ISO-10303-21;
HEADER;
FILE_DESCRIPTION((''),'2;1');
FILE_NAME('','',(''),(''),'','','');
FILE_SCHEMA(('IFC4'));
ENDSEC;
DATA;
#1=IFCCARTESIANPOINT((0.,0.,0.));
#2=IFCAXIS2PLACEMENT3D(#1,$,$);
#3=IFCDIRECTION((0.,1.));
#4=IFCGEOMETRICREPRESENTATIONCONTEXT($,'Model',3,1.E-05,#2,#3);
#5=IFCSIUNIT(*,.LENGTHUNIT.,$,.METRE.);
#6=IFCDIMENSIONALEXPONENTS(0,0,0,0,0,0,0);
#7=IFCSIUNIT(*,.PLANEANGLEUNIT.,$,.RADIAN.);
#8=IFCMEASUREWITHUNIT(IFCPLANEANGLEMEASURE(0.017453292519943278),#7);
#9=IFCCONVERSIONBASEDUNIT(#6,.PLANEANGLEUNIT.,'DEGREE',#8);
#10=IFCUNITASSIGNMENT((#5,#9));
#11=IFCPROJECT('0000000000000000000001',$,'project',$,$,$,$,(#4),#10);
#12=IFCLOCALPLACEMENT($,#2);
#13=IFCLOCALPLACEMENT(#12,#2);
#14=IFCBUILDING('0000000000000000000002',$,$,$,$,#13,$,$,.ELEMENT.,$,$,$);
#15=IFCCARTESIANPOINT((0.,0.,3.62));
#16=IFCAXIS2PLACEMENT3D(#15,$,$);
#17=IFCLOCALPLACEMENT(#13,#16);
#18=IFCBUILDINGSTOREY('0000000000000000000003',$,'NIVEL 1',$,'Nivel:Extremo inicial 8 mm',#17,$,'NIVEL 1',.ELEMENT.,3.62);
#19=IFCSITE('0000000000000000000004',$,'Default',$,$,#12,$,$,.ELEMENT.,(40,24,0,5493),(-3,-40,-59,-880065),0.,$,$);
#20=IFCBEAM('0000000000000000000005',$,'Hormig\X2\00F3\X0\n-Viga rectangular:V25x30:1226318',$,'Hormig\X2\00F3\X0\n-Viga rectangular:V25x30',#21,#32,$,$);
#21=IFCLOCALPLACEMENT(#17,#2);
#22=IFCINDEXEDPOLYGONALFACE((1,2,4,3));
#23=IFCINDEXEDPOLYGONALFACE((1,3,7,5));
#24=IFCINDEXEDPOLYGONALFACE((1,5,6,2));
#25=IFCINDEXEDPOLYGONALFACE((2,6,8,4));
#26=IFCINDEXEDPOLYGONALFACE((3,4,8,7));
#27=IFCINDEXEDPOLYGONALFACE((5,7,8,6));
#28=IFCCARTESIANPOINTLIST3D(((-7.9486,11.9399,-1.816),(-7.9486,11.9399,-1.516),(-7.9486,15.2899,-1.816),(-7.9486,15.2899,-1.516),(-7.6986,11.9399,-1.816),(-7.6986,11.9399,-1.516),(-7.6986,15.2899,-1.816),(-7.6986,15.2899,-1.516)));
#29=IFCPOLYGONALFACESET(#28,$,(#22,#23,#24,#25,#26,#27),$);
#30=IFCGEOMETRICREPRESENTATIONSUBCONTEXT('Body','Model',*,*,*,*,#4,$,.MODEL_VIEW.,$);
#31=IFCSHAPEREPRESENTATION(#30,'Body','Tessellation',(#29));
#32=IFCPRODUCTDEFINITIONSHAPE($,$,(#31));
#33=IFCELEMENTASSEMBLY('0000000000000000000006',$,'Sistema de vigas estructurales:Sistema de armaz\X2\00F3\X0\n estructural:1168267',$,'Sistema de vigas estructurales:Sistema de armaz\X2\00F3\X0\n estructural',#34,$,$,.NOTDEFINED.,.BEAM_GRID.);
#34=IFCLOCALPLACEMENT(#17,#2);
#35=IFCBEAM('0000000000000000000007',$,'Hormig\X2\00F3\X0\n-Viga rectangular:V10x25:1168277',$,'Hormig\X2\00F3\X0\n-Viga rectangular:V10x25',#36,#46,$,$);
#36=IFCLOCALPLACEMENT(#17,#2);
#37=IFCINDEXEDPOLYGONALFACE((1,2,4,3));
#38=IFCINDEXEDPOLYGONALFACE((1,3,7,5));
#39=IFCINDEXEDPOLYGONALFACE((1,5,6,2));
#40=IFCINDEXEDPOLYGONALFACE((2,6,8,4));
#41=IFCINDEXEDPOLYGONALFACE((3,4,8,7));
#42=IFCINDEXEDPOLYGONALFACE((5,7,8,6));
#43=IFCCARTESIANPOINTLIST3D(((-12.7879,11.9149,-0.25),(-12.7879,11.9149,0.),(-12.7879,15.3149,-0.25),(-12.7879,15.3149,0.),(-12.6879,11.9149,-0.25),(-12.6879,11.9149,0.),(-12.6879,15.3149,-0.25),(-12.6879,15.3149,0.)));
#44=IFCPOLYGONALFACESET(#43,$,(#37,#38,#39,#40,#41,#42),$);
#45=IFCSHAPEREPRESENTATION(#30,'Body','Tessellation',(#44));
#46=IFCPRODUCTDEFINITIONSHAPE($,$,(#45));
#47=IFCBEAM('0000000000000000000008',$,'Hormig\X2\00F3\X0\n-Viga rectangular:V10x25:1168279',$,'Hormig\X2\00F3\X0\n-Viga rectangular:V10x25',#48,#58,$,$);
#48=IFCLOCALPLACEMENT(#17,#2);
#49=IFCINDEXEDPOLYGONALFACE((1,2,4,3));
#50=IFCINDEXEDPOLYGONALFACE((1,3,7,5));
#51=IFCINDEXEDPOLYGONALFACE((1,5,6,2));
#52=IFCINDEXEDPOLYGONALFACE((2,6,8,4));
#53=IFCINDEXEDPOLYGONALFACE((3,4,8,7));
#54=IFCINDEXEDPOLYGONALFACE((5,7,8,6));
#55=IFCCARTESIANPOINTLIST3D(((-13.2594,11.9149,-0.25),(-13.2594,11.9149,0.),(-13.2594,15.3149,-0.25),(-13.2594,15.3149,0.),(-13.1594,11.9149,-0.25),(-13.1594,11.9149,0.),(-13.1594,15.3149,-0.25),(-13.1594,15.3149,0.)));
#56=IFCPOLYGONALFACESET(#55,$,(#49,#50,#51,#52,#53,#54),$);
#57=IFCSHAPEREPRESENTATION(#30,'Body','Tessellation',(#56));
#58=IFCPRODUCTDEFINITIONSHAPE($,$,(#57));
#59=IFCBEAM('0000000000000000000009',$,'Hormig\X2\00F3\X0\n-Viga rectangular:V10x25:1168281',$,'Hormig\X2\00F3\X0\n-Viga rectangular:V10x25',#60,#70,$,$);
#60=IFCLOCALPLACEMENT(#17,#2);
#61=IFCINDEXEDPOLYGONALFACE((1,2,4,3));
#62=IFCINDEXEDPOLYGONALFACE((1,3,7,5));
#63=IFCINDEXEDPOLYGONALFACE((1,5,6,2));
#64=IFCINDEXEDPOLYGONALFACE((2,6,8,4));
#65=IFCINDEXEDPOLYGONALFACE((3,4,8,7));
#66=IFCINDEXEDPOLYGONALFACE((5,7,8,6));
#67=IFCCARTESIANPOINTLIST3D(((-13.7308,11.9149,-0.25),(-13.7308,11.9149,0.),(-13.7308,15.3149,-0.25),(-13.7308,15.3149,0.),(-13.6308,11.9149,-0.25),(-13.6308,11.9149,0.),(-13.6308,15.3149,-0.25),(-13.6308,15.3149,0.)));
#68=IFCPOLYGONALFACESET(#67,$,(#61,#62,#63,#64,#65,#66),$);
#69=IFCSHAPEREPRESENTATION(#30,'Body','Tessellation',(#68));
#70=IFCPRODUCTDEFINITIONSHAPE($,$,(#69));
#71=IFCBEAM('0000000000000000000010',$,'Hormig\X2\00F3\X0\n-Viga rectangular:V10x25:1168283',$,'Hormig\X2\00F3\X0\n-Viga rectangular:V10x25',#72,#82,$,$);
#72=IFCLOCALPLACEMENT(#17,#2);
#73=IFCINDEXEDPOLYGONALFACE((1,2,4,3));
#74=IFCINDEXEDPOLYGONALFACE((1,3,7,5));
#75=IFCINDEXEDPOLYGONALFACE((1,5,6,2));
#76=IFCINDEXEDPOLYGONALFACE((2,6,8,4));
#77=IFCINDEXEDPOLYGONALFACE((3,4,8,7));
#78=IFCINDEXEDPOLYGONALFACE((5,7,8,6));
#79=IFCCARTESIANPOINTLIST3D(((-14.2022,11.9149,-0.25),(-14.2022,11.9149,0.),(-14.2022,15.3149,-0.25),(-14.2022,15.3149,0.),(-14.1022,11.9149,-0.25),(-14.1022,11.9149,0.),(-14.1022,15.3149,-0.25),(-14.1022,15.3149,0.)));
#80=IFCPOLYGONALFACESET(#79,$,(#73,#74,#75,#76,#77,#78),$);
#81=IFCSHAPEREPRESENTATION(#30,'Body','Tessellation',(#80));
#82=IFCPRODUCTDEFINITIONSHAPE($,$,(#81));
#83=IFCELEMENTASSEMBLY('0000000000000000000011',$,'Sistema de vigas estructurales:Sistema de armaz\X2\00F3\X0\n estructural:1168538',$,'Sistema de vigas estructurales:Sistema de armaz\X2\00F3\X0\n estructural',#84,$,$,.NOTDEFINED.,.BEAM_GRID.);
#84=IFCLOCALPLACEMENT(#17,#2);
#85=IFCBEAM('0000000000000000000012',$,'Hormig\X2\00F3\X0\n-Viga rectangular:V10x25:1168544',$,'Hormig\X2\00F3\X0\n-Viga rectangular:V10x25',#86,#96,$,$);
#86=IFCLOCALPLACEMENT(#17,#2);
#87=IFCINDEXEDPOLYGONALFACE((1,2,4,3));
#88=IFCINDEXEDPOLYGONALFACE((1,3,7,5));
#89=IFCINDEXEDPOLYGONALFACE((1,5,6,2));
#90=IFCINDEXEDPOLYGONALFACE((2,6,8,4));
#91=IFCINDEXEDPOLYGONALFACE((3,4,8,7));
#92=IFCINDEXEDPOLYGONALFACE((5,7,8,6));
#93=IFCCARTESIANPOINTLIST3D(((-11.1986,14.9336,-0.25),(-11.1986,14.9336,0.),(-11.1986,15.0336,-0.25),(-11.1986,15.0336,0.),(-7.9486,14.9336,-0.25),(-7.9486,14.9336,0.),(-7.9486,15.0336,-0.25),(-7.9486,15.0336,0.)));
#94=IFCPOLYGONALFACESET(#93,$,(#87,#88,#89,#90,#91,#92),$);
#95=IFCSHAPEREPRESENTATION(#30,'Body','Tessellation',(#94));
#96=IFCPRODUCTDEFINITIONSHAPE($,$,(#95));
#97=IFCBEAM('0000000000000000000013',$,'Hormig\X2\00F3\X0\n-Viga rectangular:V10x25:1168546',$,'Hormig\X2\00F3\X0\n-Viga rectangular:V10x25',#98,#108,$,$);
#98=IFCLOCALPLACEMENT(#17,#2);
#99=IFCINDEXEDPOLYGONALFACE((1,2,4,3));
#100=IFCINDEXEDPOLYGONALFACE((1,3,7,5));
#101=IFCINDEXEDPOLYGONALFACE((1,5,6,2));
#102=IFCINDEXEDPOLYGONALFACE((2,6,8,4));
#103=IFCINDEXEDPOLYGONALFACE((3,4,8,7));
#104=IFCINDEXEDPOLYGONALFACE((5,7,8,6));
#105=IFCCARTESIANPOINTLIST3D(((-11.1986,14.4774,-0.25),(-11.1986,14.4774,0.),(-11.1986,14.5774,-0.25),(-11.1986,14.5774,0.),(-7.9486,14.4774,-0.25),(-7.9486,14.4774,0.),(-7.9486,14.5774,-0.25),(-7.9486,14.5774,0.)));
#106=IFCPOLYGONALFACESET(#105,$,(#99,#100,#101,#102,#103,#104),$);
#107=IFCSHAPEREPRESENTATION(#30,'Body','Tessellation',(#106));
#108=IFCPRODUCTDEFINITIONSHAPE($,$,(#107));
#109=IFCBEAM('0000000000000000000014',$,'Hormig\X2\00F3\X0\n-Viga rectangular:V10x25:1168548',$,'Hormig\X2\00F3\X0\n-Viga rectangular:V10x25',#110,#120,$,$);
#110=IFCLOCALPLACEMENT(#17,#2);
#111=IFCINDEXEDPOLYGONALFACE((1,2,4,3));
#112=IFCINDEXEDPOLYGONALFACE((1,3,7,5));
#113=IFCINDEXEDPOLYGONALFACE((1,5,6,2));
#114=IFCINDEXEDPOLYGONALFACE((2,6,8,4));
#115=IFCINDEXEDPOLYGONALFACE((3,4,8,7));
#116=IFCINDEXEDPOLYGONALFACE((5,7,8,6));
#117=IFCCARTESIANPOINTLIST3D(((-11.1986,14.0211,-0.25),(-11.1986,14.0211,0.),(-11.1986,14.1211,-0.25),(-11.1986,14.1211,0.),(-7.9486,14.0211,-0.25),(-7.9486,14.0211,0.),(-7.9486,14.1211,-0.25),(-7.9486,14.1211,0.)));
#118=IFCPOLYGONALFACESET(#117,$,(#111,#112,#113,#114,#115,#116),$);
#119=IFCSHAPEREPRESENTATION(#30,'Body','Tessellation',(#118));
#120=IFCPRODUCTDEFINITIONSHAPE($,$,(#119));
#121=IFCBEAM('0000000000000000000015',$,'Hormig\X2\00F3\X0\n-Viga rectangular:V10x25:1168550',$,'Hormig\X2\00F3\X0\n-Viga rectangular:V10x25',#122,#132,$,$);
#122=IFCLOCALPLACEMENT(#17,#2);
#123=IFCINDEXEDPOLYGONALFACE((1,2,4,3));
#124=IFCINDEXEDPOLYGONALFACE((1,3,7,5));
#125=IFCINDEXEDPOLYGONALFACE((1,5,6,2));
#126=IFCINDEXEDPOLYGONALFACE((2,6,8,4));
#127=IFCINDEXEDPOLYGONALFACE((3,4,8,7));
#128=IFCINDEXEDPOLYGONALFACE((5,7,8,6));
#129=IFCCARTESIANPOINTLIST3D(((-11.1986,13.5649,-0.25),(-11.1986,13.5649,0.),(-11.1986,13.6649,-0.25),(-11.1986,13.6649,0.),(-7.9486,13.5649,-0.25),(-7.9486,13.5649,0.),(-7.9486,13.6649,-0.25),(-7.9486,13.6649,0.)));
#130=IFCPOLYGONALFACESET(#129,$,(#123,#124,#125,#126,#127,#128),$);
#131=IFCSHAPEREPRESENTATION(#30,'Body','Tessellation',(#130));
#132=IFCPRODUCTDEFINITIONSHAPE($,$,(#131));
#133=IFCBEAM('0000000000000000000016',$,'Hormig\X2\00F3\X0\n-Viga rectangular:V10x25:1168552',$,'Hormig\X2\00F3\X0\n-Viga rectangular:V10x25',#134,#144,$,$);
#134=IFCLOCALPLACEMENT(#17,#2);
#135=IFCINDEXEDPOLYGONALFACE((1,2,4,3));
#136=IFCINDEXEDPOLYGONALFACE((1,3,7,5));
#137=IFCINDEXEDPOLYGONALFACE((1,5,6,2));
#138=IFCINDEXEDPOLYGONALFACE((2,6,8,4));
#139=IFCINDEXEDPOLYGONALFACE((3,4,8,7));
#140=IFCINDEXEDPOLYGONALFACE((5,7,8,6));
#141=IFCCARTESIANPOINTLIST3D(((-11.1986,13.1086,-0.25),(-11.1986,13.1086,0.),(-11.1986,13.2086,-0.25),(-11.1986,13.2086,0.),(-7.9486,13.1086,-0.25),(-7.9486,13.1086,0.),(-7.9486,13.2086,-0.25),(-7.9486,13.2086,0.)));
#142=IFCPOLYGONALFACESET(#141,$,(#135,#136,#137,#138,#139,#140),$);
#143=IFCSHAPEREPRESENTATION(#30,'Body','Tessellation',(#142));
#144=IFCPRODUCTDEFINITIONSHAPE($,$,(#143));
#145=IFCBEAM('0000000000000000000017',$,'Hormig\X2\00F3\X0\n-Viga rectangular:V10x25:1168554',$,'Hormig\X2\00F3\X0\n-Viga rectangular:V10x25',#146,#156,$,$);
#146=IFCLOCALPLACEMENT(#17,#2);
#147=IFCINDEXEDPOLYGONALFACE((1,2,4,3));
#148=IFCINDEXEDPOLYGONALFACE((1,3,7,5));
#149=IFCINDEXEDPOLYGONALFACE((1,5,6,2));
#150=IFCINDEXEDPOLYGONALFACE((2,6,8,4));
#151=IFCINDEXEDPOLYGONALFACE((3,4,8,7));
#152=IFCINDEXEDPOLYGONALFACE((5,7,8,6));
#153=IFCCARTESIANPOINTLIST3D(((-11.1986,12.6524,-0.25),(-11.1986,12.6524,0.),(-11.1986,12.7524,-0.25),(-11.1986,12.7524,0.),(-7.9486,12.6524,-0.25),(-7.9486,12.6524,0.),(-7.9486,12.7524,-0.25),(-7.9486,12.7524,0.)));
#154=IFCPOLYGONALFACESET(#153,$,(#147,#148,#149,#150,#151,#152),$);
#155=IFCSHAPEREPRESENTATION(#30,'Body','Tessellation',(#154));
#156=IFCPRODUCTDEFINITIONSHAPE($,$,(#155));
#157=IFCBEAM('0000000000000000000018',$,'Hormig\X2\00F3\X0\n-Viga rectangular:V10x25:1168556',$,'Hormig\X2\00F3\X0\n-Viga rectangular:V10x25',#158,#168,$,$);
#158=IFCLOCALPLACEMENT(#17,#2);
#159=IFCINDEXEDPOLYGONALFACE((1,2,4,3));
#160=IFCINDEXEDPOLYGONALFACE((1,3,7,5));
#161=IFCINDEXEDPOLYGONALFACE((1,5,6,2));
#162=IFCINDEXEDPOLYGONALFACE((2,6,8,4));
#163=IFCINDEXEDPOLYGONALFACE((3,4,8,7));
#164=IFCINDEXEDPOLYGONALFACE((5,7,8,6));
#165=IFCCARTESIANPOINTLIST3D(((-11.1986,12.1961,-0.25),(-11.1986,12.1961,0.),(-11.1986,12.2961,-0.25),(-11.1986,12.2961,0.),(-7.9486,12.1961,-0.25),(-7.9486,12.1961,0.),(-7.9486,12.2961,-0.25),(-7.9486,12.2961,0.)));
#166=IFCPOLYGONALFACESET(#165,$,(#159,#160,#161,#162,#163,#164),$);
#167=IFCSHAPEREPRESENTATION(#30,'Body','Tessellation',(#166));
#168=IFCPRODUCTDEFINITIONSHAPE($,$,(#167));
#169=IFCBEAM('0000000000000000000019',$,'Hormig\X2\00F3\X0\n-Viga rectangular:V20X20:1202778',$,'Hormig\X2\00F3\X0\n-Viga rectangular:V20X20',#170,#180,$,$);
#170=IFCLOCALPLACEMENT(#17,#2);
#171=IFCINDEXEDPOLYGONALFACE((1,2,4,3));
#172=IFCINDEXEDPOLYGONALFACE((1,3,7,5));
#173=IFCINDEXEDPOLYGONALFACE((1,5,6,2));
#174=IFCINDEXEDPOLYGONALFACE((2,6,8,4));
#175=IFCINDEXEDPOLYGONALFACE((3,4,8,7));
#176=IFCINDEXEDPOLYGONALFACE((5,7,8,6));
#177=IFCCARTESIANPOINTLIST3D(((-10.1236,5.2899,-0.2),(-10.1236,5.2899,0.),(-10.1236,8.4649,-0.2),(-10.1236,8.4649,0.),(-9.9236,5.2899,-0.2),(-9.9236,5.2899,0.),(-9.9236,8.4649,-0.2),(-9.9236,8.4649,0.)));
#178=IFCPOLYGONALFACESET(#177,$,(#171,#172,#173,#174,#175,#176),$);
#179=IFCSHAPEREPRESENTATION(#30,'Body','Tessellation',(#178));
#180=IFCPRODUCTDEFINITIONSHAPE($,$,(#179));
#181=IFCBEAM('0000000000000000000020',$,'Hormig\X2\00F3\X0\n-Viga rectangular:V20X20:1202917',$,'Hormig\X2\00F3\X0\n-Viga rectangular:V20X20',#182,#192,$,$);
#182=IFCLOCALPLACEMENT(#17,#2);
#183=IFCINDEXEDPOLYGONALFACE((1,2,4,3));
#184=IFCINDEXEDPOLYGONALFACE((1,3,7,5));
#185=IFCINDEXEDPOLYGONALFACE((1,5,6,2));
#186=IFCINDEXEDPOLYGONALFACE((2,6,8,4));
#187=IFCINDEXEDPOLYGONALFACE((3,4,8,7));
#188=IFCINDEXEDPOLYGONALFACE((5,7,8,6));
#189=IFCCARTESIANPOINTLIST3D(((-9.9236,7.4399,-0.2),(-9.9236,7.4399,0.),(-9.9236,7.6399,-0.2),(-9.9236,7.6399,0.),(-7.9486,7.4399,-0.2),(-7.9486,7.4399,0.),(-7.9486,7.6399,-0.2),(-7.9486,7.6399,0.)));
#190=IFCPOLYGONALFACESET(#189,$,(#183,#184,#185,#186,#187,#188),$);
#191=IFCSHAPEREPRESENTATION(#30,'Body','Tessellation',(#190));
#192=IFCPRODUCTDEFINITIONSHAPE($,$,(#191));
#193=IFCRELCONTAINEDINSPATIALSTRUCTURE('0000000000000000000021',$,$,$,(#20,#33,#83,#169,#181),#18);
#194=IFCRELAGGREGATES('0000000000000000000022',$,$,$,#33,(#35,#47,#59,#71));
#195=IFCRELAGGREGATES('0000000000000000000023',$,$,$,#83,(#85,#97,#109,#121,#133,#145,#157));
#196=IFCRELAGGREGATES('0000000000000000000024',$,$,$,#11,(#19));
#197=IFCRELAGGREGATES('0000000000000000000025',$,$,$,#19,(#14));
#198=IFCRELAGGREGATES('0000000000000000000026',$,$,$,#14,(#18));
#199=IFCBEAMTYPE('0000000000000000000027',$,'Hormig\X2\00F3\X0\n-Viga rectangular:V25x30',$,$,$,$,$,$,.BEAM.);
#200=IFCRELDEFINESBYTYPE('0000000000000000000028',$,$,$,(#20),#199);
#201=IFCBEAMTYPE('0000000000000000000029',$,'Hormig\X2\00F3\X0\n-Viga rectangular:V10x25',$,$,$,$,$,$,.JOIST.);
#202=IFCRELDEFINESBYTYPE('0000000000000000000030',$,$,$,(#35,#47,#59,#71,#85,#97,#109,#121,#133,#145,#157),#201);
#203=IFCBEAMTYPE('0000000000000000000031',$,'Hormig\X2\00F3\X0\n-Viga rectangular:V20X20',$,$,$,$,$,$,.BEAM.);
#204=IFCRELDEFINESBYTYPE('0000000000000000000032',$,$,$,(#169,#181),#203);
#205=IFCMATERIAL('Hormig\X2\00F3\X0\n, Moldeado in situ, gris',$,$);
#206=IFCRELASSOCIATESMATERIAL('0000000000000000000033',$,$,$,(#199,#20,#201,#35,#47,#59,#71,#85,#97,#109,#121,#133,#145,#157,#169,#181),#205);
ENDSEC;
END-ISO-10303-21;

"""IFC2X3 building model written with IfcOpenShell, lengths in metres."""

from ifc_helpers import new_model, entity, si_unit, converted_unit, direction, frame, frame_2d, origin, place, context, subcontext, project, spatial, rectangle, extrude, material, type_object, element, aggregate, save


model = new_model("IFC2X3")

# Units and contexts
model_context = context("Model", 3, precision=1e-05, world=origin(), true_north=direction((0.0, 1.0)))
body_context = subcontext(model_context, "Body", "Model", "MODEL_VIEW")
ifc_project = project(units=[si_unit("LENGTHUNIT", "METRE"), converted_unit("PLANEANGLEUNIT", "DEGREE", entity("IfcPlaneAngleMeasure", 0.017453292519943278), si_unit("PLANEANGLEUNIT", "RADIAN"), dimensions=[0, 0, 0, 0, 0, 0, 0])], contexts=[model_context])

# Site, building, storey
site_placement = place(None, origin())
site = spatial("IfcSite", under=ifc_project, at=site_placement, Name="Default", CompositionType="ELEMENT", RefLatitude=(40, 24, 0, 5493), RefLongitude=(-3, -40, -59, -880065), RefElevation=0.0)
building_placement = place(site_placement, origin())
building = spatial("IfcBuilding", under=site, at=building_placement, CompositionType="ELEMENT")
storey_placement = place(building_placement, frame((0.0, 0.0, 3.62)))
storey = spatial("IfcBuildingStorey", under=building, at=storey_placement, Name="NIVEL 1", ObjectType="Nivel:Extremo inicial 8 mm", LongName="NIVEL 1", CompositionType="ELEMENT", Elevation=3.62)

# Beam
ifc_material_1 = material(Name="Hormigón, Moldeado in situ, gris")
beam_type_1 = type_object("IfcBeamType", Name="Hormigón-Viga rectangular:V25x30", PredefinedType="BEAM", material=ifc_material_1)
beam_1_placement = place(storey_placement, frame((-7.8236, 15.4399, -1.516), z_axis=(0.0, 0.0, 1.0), x_axis=(0.0, -1.0, 0.0)))
element("IfcBeam", 1, at=beam_1_placement, inside=storey, type_object=beam_type_1, material=ifc_material_1, Name="Hormigón-Viga rectangular:V25x30:1226318", ObjectType="Hormigón-Viga rectangular:V25x30", context=body_context, shape_type="SweptSolid", body=[
    extrude(rectangle(XDim=0.3, YDim=0.25, at=frame_2d((0.0, 0.0), x_axis=(1.0, 0.0))), frame((0.15, 0.0, -0.15), z_axis=(1.0, 0.0, 0.0), x_axis=(0.0, 0.0, -1.0)), (0.0, 0.0, 1.0), 3.35),
])

# Element assemblies, beams
assembly_1_placement = place(storey_placement, origin())
assembly_1 = element("IfcElementAssembly", 2, at=assembly_1_placement, inside=storey, Name="Sistema de vigas estructurales:Sistema de armazón estructural:1168267", ObjectType="Sistema de vigas estructurales:Sistema de armazón estructural", AssemblyPlace="NOTDEFINED", PredefinedType="BEAM_GRID")
beam_type_2 = type_object("IfcBeamType", Name="Hormigón-Viga rectangular:V10x25", PredefinedType="JOIST", material=ifc_material_1)
beam_2_placement = place(assembly_1_placement, frame((-12.7379, 15.4399, 0.0), z_axis=(0.0, 0.0, 1.0), x_axis=(0.0, -1.0, 0.0)))
beam_2 = element("IfcBeam", 3, at=beam_2_placement, type_object=beam_type_2, material=ifc_material_1, Name="Hormigón-Viga rectangular:V10x25:1168277", ObjectType="Hormigón-Viga rectangular:V10x25", context=body_context, shape_type="SweptSolid", body=[
    extrude(rectangle(XDim=0.25, YDim=0.1, at=frame_2d((0.0, 0.0), x_axis=(1.0, 0.0))), frame((0.125, 0.0, -0.125), z_axis=(1.0, 0.0, 0.0), x_axis=(0.0, 0.0, -1.0)), (0.0, 0.0, 1.0), 3.4),
])
beam_3_placement = place(assembly_1_placement, frame((-13.2094, 15.4399, 0.0), z_axis=(0.0, 0.0, 1.0), x_axis=(0.0, -1.0, 0.0)))
beam_3 = element("IfcBeam", 4, at=beam_3_placement, type_object=beam_type_2, material=ifc_material_1, Name="Hormigón-Viga rectangular:V10x25:1168279", ObjectType="Hormigón-Viga rectangular:V10x25", context=body_context, shape_type="SweptSolid", body=[
    extrude(rectangle(XDim=0.25, YDim=0.1, at=frame_2d((0.0, 0.0), x_axis=(1.0, 0.0))), frame((0.125, 0.0, -0.125), z_axis=(1.0, 0.0, 0.0), x_axis=(0.0, 0.0, -1.0)), (0.0, 0.0, 1.0), 3.4),
])
beam_4_placement = place(assembly_1_placement, frame((-13.6808, 15.4399, 0.0), z_axis=(0.0, 0.0, 1.0), x_axis=(0.0, -1.0, 0.0)))
beam_4 = element("IfcBeam", 5, at=beam_4_placement, type_object=beam_type_2, material=ifc_material_1, Name="Hormigón-Viga rectangular:V10x25:1168281", ObjectType="Hormigón-Viga rectangular:V10x25", context=body_context, shape_type="SweptSolid", body=[
    extrude(rectangle(XDim=0.25, YDim=0.1, at=frame_2d((0.0, 0.0), x_axis=(1.0, 0.0))), frame((0.125, 0.0, -0.125), z_axis=(1.0, 0.0, 0.0), x_axis=(0.0, 0.0, -1.0)), (0.0, 0.0, 1.0), 3.4),
])
beam_5_placement = place(assembly_1_placement, frame((-14.1522, 15.4399, 0.0), z_axis=(0.0, 0.0, 1.0), x_axis=(0.0, -1.0, 0.0)))
beam_5 = element("IfcBeam", 6, at=beam_5_placement, type_object=beam_type_2, material=ifc_material_1, Name="Hormigón-Viga rectangular:V10x25:1168283", ObjectType="Hormigón-Viga rectangular:V10x25", context=body_context, shape_type="SweptSolid", body=[
    extrude(rectangle(XDim=0.25, YDim=0.1, at=frame_2d((0.0, 0.0), x_axis=(1.0, 0.0))), frame((0.125, 0.0, -0.125), z_axis=(1.0, 0.0, 0.0), x_axis=(0.0, 0.0, -1.0)), (0.0, 0.0, 1.0), 3.4),
])
aggregate(assembly_1, [beam_2, beam_3, beam_4, beam_5])
assembly_2_placement = place(storey_placement, origin())
assembly_2 = element("IfcElementAssembly", 7, at=assembly_2_placement, inside=storey, Name="Sistema de vigas estructurales:Sistema de armazón estructural:1168538", ObjectType="Sistema de vigas estructurales:Sistema de armazón estructural", AssemblyPlace="NOTDEFINED", PredefinedType="BEAM_GRID")
beam_6_placement = place(assembly_2_placement, frame((-11.3236, 14.9836, 0.0)))
beam_6 = element("IfcBeam", 8, at=beam_6_placement, type_object=beam_type_2, material=ifc_material_1, Name="Hormigón-Viga rectangular:V10x25:1168544", ObjectType="Hormigón-Viga rectangular:V10x25", context=body_context, shape_type="SweptSolid", body=[
    extrude(rectangle(XDim=0.25, YDim=0.1, at=frame_2d((0.0, 0.0), x_axis=(1.0, 0.0))), frame((0.125, 0.0, -0.125), z_axis=(1.0, 0.0, 0.0), x_axis=(0.0, 0.0, -1.0)), (0.0, 0.0, 1.0), 3.25),
])
beam_7_placement = place(assembly_2_placement, frame((-11.3236, 14.5274, 0.0)))
beam_7 = element("IfcBeam", 9, at=beam_7_placement, type_object=beam_type_2, material=ifc_material_1, Name="Hormigón-Viga rectangular:V10x25:1168546", ObjectType="Hormigón-Viga rectangular:V10x25", context=body_context, shape_type="SweptSolid", body=[
    extrude(rectangle(XDim=0.25, YDim=0.1, at=frame_2d((0.0, 0.0), x_axis=(1.0, 0.0))), frame((0.125, 0.0, -0.125), z_axis=(1.0, 0.0, 0.0), x_axis=(0.0, 0.0, -1.0)), (0.0, 0.0, 1.0), 3.25),
])
beam_8_placement = place(assembly_2_placement, frame((-11.3236, 14.0711, 0.0)))
beam_8 = element("IfcBeam", 10, at=beam_8_placement, type_object=beam_type_2, material=ifc_material_1, Name="Hormigón-Viga rectangular:V10x25:1168548", ObjectType="Hormigón-Viga rectangular:V10x25", context=body_context, shape_type="SweptSolid", body=[
    extrude(rectangle(XDim=0.25, YDim=0.1, at=frame_2d((0.0, 0.0), x_axis=(1.0, 0.0))), frame((0.125, 0.0, -0.125), z_axis=(1.0, 0.0, 0.0), x_axis=(0.0, 0.0, -1.0)), (0.0, 0.0, 1.0), 3.25),
])
beam_9_placement = place(assembly_2_placement, frame((-11.3236, 13.6149, 0.0)))
beam_9 = element("IfcBeam", 11, at=beam_9_placement, type_object=beam_type_2, material=ifc_material_1, Name="Hormigón-Viga rectangular:V10x25:1168550", ObjectType="Hormigón-Viga rectangular:V10x25", context=body_context, shape_type="SweptSolid", body=[
    extrude(rectangle(XDim=0.25, YDim=0.1, at=frame_2d((0.0, 0.0), x_axis=(1.0, 0.0))), frame((0.125, 0.0, -0.125), z_axis=(1.0, 0.0, 0.0), x_axis=(0.0, 0.0, -1.0)), (0.0, 0.0, 1.0), 3.25),
])
beam_10_placement = place(assembly_2_placement, frame((-11.3236, 13.1586, 0.0)))
beam_10 = element("IfcBeam", 12, at=beam_10_placement, type_object=beam_type_2, material=ifc_material_1, Name="Hormigón-Viga rectangular:V10x25:1168552", ObjectType="Hormigón-Viga rectangular:V10x25", context=body_context, shape_type="SweptSolid", body=[
    extrude(rectangle(XDim=0.25, YDim=0.1, at=frame_2d((0.0, 0.0), x_axis=(1.0, 0.0))), frame((0.125, 0.0, -0.125), z_axis=(1.0, 0.0, 0.0), x_axis=(0.0, 0.0, -1.0)), (0.0, 0.0, 1.0), 3.25),
])
beam_11_placement = place(assembly_2_placement, frame((-11.3236, 12.7024, 0.0)))
beam_11 = element("IfcBeam", 13, at=beam_11_placement, type_object=beam_type_2, material=ifc_material_1, Name="Hormigón-Viga rectangular:V10x25:1168554", ObjectType="Hormigón-Viga rectangular:V10x25", context=body_context, shape_type="SweptSolid", body=[
    extrude(rectangle(XDim=0.25, YDim=0.1, at=frame_2d((0.0, 0.0), x_axis=(1.0, 0.0))), frame((0.125, 0.0, -0.125), z_axis=(1.0, 0.0, 0.0), x_axis=(0.0, 0.0, -1.0)), (0.0, 0.0, 1.0), 3.25),
])
beam_12_placement = place(assembly_2_placement, frame((-11.3236, 12.2461, 0.0)))
beam_12 = element("IfcBeam", 14, at=beam_12_placement, type_object=beam_type_2, material=ifc_material_1, Name="Hormigón-Viga rectangular:V10x25:1168556", ObjectType="Hormigón-Viga rectangular:V10x25", context=body_context, shape_type="SweptSolid", body=[
    extrude(rectangle(XDim=0.25, YDim=0.1, at=frame_2d((0.0, 0.0), x_axis=(1.0, 0.0))), frame((0.125, 0.0, -0.125), z_axis=(1.0, 0.0, 0.0), x_axis=(0.0, 0.0, -1.0)), (0.0, 0.0, 1.0), 3.25),
])
aggregate(assembly_2, [beam_6, beam_7, beam_8, beam_9, beam_10, beam_11, beam_12])

# Beams
beam_type_3 = type_object("IfcBeamType", Name="Hormigón-Viga rectangular:V20X20", PredefinedType="BEAM")
beam_13_placement = place(storey_placement, frame((-10.0236, 5.1899, 0.0), z_axis=(0.0, 0.0, 1.0), x_axis=(0.0, 1.0, 0.0)))
element("IfcBeam", 15, at=beam_13_placement, inside=storey, type_object=beam_type_3, material=ifc_material_1, Name="Hormigón-Viga rectangular:V20X20:1202778", ObjectType="Hormigón-Viga rectangular:V20X20", context=body_context, shape_type="SweptSolid", body=[
    extrude(rectangle(XDim=0.2, YDim=0.2, at=frame_2d((0.0, 0.0), x_axis=(1.0, 0.0))), frame((0.1, 0.0, -0.1), z_axis=(1.0, 0.0, 0.0), x_axis=(0.0, 0.0, -1.0)), (0.0, 0.0, 1.0), 3.175),
])
beam_14_placement = place(storey_placement, frame((-10.0236, 7.5399, 0.0)))
element("IfcBeam", 16, at=beam_14_placement, inside=storey, type_object=beam_type_3, material=ifc_material_1, Name="Hormigón-Viga rectangular:V20X20:1202917", ObjectType="Hormigón-Viga rectangular:V20X20", context=body_context, shape_type="SweptSolid", body=[
    extrude(rectangle(XDim=0.2, YDim=0.2, at=frame_2d((0.0, 0.0), x_axis=(1.0, 0.0))), frame((0.1, 0.0, -0.1), z_axis=(1.0, 0.0, 0.0), x_axis=(0.0, 0.0, -1.0)), (0.0, 0.0, 1.0), 1.975),
])

save(model, "model.ifc")
